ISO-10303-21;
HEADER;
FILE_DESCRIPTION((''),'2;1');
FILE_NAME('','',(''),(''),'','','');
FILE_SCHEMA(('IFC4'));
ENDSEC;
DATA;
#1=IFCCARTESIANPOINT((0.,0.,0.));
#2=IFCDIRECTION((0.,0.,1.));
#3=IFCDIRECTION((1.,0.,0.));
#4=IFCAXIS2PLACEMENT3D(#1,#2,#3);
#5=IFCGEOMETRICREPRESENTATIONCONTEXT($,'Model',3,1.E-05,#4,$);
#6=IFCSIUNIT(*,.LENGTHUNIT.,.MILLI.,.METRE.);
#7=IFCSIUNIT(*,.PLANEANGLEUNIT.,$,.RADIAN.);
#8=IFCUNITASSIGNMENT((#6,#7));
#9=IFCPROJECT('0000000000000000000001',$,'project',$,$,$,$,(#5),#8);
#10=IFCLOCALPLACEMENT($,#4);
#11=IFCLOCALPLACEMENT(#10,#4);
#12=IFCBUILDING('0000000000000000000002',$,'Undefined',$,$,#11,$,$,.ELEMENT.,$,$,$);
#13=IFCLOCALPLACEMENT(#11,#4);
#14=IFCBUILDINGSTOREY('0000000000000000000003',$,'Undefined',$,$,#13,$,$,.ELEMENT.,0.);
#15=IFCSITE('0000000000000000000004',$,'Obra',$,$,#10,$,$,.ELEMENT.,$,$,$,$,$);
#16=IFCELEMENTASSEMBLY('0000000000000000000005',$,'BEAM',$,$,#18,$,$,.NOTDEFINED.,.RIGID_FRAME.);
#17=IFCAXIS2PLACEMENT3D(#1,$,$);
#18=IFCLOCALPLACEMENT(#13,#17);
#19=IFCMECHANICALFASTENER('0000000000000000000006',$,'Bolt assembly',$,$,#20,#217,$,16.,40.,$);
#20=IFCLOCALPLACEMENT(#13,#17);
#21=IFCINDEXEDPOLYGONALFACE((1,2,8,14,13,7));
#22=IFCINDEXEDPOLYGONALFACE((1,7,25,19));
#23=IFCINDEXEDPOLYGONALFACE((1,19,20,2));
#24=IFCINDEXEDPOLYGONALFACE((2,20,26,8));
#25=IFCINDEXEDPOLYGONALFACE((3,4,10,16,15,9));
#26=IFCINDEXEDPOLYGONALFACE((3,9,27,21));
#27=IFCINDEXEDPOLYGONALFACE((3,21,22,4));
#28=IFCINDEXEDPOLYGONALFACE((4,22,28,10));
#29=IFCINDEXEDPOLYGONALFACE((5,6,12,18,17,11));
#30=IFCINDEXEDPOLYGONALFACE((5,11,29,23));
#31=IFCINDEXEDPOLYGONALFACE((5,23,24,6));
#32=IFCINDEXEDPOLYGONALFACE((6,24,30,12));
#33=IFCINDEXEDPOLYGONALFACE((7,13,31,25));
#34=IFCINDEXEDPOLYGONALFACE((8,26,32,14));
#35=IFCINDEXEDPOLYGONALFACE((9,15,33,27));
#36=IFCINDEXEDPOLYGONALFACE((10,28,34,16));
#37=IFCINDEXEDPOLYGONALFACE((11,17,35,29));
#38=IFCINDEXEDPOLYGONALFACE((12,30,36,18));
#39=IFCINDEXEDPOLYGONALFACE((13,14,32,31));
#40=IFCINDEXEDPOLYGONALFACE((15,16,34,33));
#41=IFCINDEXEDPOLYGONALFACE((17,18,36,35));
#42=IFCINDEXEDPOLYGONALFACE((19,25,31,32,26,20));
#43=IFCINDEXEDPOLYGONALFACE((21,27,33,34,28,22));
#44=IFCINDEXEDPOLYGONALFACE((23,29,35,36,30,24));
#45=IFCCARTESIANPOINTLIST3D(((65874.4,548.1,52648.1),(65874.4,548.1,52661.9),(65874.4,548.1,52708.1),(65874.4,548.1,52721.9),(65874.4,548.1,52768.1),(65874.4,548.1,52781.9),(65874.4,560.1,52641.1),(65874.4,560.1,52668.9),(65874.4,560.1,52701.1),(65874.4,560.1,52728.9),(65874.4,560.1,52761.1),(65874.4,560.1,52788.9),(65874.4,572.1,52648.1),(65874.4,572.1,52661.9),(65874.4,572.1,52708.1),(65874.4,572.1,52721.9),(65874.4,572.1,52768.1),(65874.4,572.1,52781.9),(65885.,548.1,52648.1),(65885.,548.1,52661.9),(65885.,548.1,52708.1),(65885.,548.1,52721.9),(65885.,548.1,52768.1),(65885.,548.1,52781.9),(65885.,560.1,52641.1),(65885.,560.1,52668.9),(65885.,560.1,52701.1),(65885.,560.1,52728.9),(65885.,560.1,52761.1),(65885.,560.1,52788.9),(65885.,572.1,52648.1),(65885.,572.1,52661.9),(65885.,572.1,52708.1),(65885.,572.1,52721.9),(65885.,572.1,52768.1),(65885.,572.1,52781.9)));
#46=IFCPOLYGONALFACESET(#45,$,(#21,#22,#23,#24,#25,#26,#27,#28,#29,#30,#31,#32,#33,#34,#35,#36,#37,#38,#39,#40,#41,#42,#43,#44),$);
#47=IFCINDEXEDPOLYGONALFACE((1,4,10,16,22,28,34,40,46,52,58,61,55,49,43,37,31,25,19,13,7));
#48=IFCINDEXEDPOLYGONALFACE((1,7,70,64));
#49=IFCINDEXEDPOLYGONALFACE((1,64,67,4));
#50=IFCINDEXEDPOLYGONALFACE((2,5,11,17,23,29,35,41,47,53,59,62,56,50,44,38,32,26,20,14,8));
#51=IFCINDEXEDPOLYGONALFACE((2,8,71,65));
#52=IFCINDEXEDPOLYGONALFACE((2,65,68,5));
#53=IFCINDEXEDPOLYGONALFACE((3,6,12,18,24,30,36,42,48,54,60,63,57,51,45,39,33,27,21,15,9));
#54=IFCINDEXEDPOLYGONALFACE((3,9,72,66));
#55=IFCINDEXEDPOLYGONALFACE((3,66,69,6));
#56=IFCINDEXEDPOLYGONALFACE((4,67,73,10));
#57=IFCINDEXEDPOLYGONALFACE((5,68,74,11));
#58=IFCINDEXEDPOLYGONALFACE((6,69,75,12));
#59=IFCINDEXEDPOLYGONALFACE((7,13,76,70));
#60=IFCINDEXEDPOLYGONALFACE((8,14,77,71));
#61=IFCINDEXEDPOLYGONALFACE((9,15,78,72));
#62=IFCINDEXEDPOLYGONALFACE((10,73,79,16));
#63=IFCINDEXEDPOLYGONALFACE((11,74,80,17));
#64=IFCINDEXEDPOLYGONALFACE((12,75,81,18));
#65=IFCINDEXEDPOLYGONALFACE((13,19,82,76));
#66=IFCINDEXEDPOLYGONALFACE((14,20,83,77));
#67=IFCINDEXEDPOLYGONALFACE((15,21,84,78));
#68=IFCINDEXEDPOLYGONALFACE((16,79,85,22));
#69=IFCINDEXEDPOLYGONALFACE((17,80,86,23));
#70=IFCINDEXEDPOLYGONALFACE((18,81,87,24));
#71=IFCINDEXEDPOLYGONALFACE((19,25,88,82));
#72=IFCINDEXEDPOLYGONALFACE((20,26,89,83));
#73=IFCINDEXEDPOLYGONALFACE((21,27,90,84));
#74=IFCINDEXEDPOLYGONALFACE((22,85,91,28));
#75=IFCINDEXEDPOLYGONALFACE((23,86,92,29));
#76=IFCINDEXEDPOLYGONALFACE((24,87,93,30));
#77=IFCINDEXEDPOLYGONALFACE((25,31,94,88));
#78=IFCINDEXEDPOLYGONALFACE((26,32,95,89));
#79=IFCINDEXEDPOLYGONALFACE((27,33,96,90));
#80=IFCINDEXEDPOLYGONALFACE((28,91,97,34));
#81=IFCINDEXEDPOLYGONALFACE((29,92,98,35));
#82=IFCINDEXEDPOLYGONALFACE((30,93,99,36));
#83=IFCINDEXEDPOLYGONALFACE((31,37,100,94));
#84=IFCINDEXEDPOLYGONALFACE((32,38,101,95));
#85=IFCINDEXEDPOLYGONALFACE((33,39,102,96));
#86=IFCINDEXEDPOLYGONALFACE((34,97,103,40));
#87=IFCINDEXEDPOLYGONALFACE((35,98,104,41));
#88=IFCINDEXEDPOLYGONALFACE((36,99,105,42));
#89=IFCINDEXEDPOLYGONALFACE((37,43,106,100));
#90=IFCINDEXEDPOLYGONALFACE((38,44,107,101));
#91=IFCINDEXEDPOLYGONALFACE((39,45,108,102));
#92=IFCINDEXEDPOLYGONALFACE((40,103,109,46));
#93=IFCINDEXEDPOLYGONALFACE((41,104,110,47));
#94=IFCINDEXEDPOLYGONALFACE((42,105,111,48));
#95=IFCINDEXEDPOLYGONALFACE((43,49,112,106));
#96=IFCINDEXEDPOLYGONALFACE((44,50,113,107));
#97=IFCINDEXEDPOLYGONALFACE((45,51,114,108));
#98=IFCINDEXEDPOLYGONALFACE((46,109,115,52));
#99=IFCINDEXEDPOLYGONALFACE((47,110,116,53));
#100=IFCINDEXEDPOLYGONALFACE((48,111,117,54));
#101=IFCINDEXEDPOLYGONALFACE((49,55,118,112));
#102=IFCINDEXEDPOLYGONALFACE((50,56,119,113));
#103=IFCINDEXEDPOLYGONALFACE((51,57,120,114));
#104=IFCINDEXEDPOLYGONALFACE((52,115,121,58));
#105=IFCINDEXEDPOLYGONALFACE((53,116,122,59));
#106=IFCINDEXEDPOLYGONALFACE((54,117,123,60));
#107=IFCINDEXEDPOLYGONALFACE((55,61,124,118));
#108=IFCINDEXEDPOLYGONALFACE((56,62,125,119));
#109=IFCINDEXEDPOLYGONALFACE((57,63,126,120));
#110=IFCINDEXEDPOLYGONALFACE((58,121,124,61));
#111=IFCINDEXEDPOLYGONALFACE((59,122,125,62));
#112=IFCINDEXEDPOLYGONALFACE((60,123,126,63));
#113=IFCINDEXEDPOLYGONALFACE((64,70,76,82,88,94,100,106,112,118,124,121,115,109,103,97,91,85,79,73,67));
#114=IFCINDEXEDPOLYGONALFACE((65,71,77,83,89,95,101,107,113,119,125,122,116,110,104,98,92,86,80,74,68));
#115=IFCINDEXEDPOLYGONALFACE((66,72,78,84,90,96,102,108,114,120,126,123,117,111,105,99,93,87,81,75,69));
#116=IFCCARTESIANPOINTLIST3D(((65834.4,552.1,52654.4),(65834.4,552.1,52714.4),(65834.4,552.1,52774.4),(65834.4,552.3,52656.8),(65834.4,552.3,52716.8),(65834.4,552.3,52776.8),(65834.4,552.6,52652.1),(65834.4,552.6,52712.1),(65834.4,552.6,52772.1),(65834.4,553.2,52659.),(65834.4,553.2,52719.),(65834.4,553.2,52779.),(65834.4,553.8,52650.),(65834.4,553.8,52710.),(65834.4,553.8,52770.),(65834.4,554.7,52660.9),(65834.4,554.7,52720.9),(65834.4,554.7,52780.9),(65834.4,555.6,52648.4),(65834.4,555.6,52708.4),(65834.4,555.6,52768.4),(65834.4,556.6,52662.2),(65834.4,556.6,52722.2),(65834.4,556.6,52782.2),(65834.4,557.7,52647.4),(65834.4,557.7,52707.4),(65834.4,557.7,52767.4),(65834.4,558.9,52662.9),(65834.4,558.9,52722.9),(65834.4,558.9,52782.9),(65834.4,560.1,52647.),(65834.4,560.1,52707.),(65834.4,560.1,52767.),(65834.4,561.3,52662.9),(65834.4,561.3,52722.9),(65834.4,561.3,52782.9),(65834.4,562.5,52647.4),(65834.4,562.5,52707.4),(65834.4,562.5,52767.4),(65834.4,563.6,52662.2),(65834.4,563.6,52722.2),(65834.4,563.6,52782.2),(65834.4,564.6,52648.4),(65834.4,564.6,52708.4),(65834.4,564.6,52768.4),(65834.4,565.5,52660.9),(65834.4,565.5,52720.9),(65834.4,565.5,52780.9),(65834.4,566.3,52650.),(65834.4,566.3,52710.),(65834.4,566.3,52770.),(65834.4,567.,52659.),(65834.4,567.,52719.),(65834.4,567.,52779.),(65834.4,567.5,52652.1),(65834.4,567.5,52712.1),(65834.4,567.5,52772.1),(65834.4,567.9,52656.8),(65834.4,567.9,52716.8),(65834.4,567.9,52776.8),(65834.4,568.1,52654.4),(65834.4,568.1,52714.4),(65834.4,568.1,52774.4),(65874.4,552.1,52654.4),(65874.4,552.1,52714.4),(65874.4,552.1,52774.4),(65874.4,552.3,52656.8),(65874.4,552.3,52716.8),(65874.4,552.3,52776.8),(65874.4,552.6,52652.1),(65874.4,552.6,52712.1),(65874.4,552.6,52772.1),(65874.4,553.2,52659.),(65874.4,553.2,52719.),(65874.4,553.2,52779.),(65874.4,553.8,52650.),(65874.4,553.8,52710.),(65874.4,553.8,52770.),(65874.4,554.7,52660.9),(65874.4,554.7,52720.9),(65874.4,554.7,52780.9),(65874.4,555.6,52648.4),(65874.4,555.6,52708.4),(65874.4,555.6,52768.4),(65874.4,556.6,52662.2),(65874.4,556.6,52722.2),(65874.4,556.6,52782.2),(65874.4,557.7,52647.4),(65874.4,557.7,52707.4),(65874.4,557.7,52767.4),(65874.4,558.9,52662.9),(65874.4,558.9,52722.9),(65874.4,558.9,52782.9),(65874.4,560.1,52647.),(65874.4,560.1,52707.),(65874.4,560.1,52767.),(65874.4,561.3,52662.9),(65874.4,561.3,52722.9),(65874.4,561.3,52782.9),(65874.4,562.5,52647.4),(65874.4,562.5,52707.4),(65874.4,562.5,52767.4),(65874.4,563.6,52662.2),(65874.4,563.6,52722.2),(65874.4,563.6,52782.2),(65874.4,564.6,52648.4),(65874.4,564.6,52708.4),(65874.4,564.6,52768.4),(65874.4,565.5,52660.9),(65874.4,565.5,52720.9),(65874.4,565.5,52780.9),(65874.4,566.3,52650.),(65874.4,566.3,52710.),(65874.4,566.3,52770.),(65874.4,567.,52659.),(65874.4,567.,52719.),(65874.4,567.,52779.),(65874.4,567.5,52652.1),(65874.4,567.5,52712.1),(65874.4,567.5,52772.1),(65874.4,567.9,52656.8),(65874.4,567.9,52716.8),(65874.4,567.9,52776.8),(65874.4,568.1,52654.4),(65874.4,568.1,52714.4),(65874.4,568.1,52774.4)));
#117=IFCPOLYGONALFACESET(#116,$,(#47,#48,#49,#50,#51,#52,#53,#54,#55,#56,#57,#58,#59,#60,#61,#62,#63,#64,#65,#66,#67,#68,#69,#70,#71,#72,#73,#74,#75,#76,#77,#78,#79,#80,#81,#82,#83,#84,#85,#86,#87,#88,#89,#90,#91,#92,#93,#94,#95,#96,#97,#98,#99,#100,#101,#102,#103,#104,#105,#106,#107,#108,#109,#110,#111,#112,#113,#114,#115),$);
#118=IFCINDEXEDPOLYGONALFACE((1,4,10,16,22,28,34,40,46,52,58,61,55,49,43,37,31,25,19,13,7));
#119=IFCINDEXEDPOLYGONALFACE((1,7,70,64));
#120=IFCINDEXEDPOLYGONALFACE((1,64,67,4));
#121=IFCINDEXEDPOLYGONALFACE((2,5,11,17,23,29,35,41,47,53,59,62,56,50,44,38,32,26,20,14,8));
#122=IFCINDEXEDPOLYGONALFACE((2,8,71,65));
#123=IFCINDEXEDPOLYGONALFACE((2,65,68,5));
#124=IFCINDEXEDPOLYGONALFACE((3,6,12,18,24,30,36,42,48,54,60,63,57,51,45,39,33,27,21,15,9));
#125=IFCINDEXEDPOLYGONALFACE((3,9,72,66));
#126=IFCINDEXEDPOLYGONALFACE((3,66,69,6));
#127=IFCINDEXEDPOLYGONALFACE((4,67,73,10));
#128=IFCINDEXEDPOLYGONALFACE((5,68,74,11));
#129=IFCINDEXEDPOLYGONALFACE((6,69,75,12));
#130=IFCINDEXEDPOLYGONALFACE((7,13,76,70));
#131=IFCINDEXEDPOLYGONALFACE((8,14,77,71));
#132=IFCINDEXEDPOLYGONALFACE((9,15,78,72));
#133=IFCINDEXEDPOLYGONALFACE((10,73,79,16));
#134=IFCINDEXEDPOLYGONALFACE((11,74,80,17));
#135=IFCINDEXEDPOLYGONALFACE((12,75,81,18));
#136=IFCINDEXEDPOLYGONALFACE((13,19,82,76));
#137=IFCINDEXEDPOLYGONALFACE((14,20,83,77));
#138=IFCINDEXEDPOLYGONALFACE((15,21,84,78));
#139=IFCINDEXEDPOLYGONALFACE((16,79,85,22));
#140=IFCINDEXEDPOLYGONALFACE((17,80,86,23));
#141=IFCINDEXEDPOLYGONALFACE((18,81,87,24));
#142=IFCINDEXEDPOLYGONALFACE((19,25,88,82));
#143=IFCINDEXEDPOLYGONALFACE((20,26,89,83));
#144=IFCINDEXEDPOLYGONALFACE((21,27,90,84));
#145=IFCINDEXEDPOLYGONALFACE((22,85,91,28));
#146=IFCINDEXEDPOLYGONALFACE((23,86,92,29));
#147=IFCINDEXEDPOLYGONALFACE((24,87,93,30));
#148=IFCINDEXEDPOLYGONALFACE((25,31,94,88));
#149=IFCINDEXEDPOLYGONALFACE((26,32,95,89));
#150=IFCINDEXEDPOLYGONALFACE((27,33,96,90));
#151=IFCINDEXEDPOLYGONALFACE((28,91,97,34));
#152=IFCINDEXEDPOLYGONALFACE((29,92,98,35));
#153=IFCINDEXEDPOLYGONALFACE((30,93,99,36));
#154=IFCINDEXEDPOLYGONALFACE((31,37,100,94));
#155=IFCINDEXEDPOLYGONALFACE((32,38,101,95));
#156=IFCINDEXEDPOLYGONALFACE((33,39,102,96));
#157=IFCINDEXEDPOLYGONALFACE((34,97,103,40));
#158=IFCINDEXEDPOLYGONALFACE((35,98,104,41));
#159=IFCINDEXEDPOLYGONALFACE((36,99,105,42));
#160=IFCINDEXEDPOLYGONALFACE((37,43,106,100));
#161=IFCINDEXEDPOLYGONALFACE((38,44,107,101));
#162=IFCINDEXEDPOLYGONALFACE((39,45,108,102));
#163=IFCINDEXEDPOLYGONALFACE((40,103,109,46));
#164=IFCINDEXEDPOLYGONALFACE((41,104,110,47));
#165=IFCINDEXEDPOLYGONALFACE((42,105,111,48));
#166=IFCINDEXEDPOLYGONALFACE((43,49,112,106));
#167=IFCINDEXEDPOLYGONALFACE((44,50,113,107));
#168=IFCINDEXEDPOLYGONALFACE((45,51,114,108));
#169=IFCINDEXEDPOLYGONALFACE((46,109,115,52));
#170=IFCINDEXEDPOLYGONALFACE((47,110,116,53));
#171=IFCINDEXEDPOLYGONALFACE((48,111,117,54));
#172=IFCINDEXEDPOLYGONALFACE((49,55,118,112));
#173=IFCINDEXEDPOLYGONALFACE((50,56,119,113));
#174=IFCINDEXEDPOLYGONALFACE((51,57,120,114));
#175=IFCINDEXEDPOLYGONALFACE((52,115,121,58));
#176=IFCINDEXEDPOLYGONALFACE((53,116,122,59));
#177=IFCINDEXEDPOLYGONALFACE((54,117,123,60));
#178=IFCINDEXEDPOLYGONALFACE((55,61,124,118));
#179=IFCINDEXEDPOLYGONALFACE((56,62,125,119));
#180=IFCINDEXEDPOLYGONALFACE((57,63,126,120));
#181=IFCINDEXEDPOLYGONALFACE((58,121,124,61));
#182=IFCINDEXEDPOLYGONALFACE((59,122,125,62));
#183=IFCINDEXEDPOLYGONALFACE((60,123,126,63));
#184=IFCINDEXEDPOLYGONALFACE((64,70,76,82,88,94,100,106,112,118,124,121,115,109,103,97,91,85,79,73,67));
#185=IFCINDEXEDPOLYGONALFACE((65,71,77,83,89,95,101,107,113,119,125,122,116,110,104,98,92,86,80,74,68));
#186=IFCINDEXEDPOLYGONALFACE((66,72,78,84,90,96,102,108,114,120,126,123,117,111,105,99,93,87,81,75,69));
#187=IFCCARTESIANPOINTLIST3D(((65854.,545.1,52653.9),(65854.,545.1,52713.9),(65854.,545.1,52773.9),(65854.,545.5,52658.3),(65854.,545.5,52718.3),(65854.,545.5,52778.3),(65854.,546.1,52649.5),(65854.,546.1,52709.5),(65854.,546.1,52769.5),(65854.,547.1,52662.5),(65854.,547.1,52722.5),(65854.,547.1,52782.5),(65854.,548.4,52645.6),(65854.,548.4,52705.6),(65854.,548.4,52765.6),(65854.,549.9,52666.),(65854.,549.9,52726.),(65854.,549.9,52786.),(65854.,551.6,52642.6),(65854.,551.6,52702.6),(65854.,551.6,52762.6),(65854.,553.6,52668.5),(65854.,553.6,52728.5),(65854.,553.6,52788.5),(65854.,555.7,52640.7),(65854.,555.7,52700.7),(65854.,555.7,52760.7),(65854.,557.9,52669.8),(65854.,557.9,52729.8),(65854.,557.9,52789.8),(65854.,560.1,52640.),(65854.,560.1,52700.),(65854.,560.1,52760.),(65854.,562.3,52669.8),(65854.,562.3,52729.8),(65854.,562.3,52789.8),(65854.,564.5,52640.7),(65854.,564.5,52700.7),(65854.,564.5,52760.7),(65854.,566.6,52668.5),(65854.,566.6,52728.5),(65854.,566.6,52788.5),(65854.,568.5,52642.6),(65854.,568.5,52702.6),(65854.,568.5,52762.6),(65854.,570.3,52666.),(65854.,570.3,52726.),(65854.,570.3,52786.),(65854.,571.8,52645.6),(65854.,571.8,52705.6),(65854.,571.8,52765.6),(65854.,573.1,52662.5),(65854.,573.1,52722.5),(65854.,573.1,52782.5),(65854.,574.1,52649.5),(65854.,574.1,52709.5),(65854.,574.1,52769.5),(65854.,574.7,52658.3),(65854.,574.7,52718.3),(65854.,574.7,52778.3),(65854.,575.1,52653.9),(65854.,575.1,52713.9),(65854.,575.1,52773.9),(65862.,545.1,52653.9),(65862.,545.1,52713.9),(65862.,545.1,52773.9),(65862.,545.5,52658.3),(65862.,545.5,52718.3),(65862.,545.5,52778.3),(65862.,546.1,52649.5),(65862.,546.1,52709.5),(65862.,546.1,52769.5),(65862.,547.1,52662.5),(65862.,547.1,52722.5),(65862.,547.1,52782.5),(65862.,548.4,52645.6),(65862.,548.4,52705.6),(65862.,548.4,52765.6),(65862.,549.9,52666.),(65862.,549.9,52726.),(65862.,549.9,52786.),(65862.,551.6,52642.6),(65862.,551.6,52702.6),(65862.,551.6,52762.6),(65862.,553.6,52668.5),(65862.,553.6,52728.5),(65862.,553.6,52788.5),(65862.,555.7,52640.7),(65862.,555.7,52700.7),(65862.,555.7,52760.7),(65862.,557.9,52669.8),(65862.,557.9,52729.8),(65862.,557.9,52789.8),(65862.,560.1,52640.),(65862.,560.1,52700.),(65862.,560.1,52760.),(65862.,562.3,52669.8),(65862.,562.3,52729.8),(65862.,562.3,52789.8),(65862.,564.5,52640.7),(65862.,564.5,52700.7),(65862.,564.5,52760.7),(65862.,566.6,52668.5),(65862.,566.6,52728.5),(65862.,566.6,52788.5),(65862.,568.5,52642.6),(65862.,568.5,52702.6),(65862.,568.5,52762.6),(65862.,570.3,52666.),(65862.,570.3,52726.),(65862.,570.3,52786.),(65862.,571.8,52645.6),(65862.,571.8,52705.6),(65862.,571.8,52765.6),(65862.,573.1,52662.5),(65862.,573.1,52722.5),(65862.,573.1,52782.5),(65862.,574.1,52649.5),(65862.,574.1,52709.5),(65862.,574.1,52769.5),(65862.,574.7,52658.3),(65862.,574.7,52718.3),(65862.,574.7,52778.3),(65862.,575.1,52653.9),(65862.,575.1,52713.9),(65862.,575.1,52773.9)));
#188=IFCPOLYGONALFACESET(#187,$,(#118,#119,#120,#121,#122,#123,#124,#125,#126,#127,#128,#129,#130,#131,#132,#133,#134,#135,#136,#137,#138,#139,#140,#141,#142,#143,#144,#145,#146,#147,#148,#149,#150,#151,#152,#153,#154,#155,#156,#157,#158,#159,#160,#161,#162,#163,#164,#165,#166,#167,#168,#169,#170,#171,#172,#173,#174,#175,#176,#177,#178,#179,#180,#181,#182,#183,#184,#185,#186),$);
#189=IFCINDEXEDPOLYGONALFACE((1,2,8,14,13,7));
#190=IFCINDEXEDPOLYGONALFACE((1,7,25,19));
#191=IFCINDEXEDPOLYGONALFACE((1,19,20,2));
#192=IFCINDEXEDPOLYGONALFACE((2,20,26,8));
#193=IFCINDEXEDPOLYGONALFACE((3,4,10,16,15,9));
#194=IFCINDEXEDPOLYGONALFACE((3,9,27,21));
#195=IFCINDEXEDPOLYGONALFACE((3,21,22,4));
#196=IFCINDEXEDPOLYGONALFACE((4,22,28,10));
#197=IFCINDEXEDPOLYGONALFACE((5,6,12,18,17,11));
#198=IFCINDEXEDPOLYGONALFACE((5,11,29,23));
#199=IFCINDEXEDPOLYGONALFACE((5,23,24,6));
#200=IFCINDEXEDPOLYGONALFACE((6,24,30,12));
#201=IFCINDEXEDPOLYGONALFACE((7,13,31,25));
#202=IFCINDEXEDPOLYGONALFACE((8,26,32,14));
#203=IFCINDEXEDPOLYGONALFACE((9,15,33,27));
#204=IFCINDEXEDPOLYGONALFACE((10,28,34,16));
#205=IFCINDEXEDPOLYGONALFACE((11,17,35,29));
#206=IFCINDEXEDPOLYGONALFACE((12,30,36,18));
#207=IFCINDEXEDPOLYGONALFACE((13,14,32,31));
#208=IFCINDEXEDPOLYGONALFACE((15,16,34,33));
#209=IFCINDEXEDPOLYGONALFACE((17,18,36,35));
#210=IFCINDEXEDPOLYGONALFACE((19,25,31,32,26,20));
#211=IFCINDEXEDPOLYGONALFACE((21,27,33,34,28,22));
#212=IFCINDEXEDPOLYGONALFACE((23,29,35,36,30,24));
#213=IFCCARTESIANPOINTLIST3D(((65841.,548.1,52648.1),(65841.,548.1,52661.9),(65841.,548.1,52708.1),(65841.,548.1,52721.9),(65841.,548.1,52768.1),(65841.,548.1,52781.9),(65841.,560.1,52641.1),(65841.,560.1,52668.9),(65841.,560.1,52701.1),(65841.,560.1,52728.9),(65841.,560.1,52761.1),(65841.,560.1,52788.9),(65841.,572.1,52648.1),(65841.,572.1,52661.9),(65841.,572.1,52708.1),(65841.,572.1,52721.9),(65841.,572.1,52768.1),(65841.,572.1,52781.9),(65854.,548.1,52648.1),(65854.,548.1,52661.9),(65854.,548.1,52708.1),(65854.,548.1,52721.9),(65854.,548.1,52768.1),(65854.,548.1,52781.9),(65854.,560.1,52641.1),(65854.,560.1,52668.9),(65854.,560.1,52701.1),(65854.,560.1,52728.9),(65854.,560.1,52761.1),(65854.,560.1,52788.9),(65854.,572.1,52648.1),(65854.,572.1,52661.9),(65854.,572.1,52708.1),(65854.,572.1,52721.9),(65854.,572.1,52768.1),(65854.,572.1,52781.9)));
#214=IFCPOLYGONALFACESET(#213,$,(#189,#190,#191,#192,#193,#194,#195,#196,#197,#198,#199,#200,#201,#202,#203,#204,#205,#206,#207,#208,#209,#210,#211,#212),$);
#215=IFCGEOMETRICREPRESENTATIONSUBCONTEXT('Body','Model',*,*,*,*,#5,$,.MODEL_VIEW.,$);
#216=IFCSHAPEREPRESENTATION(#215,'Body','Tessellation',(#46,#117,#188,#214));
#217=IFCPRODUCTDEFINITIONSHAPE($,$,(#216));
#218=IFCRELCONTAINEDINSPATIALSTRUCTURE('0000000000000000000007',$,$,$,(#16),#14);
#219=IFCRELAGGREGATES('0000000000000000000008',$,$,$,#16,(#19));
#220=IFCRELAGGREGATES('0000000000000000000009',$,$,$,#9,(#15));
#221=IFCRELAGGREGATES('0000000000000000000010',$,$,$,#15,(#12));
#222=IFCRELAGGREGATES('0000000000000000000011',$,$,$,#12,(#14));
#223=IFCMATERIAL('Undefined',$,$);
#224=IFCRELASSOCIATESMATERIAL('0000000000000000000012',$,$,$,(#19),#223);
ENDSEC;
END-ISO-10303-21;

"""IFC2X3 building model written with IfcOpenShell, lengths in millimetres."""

from ifc_helpers import new_model, si_unit, frame, origin_with_axes, origin_2d_with_axis, place, context, subcontext, project, spatial, polyline, circle, outline, extrude, source, transform, mapped, material, element, aggregate, save


model = new_model("IFC2X3")

# Units and contexts
model_context = context("Model", 3, precision=1e-05, world=origin_with_axes())
body_context = subcontext(model_context, "Body", "Model", "MODEL_VIEW")
ifc_project = project(units=[si_unit("LENGTHUNIT", "METRE", prefix="MILLI"), si_unit("PLANEANGLEUNIT", "RADIAN")], contexts=[model_context])

# Site, building, storey
site_placement = place(None, origin_with_axes())
site = spatial("IfcSite", under=ifc_project, at=site_placement, Name="Obra", CompositionType="ELEMENT")
building_placement = place(site_placement, origin_with_axes())
building = spatial("IfcBuilding", under=site, at=building_placement, Name="Undefined", CompositionType="ELEMENT")
storey_placement = place(building_placement, origin_with_axes())
storey = spatial("IfcBuildingStorey", under=building, at=storey_placement, Name="Undefined", CompositionType="ELEMENT", Elevation=0.0)

# Element assembly, mechanical fastener
assembly_1_placement = place(storey_placement, origin_with_axes())
assembly_1 = element("IfcElementAssembly", 1, at=assembly_1_placement, inside=storey, Name="BEAM", AssemblyPlace="NOTDEFINED", PredefinedType="RIGID_FRAME")
ifc_material_1 = material(Name="Undefined")
shared_shape_1 = source(origin_with_axes(), body_context, "Body", "SweptSolid", [
    extrude(outline(polyline([(13.9, 0.0), (6.9, 12.0), (-6.9, 12.0), (-13.9, 0.0), (-6.9, -12.0), (6.9, -12.0), (13.9, 0.0)])), frame((0.0, -19.7, 0.0), z_axis=(0.0, 1.0, 0.0), x_axis=(1.0, 0.0, 0.0)), (0.0, 0.0, 1.0), 10.6),
    extrude(circle(Radius=8.0, at=origin_2d_with_axis()), frame((0.0, -9.1, 0.0), z_axis=(0.0, 1.0, 0.0), x_axis=(1.0, 0.0, 0.0)), (0.0, 0.0, 1.0), 40.0),
    extrude(circle(Radius=15.0, at=origin_2d_with_axis()), frame((0.0, 3.3, 0.0), z_axis=(0.0, 1.0, 0.0), x_axis=(1.0, 0.0, 0.0)), (0.0, 0.0, 1.0), 8.0),
    extrude(outline(polyline([(13.9, 0.0), (6.9, 12.0), (-6.9, 12.0), (-13.9, 0.0), (-6.9, -12.0), (6.9, -12.0), (13.9, 0.0)])), frame((0.0, 11.3, 0.0), z_axis=(0.0, 1.0, 0.0), x_axis=(1.0, 0.0, 0.0)), (0.0, 0.0, 1.0), 13.0),
])
mechanical_fastener_1_placement = place(assembly_1_placement, frame((65865.3, 510.1, 52835.0), z_axis=(-0.000002, 1.0, 0.0), x_axis=(0.0, 0.0, -1.0)))
mechanical_fastener_1 = element("IfcMechanicalFastener", 2, at=mechanical_fastener_1_placement, material=ifc_material_1, Name="Bolt assembly", NominalDiameter=16.0, NominalLength=40.0, context=body_context, shape_type="MappedRepresentation", body=[
    mapped(shared_shape_1, transform((60.0, 0.0, 50.0))),
    mapped(shared_shape_1, transform((120.0, 0.0, 50.0))),
    mapped(shared_shape_1, transform((180.0, 0.0, 50.0))),
])
aggregate(assembly_1, [mechanical_fastener_1])

save(model, "model.ifc")
